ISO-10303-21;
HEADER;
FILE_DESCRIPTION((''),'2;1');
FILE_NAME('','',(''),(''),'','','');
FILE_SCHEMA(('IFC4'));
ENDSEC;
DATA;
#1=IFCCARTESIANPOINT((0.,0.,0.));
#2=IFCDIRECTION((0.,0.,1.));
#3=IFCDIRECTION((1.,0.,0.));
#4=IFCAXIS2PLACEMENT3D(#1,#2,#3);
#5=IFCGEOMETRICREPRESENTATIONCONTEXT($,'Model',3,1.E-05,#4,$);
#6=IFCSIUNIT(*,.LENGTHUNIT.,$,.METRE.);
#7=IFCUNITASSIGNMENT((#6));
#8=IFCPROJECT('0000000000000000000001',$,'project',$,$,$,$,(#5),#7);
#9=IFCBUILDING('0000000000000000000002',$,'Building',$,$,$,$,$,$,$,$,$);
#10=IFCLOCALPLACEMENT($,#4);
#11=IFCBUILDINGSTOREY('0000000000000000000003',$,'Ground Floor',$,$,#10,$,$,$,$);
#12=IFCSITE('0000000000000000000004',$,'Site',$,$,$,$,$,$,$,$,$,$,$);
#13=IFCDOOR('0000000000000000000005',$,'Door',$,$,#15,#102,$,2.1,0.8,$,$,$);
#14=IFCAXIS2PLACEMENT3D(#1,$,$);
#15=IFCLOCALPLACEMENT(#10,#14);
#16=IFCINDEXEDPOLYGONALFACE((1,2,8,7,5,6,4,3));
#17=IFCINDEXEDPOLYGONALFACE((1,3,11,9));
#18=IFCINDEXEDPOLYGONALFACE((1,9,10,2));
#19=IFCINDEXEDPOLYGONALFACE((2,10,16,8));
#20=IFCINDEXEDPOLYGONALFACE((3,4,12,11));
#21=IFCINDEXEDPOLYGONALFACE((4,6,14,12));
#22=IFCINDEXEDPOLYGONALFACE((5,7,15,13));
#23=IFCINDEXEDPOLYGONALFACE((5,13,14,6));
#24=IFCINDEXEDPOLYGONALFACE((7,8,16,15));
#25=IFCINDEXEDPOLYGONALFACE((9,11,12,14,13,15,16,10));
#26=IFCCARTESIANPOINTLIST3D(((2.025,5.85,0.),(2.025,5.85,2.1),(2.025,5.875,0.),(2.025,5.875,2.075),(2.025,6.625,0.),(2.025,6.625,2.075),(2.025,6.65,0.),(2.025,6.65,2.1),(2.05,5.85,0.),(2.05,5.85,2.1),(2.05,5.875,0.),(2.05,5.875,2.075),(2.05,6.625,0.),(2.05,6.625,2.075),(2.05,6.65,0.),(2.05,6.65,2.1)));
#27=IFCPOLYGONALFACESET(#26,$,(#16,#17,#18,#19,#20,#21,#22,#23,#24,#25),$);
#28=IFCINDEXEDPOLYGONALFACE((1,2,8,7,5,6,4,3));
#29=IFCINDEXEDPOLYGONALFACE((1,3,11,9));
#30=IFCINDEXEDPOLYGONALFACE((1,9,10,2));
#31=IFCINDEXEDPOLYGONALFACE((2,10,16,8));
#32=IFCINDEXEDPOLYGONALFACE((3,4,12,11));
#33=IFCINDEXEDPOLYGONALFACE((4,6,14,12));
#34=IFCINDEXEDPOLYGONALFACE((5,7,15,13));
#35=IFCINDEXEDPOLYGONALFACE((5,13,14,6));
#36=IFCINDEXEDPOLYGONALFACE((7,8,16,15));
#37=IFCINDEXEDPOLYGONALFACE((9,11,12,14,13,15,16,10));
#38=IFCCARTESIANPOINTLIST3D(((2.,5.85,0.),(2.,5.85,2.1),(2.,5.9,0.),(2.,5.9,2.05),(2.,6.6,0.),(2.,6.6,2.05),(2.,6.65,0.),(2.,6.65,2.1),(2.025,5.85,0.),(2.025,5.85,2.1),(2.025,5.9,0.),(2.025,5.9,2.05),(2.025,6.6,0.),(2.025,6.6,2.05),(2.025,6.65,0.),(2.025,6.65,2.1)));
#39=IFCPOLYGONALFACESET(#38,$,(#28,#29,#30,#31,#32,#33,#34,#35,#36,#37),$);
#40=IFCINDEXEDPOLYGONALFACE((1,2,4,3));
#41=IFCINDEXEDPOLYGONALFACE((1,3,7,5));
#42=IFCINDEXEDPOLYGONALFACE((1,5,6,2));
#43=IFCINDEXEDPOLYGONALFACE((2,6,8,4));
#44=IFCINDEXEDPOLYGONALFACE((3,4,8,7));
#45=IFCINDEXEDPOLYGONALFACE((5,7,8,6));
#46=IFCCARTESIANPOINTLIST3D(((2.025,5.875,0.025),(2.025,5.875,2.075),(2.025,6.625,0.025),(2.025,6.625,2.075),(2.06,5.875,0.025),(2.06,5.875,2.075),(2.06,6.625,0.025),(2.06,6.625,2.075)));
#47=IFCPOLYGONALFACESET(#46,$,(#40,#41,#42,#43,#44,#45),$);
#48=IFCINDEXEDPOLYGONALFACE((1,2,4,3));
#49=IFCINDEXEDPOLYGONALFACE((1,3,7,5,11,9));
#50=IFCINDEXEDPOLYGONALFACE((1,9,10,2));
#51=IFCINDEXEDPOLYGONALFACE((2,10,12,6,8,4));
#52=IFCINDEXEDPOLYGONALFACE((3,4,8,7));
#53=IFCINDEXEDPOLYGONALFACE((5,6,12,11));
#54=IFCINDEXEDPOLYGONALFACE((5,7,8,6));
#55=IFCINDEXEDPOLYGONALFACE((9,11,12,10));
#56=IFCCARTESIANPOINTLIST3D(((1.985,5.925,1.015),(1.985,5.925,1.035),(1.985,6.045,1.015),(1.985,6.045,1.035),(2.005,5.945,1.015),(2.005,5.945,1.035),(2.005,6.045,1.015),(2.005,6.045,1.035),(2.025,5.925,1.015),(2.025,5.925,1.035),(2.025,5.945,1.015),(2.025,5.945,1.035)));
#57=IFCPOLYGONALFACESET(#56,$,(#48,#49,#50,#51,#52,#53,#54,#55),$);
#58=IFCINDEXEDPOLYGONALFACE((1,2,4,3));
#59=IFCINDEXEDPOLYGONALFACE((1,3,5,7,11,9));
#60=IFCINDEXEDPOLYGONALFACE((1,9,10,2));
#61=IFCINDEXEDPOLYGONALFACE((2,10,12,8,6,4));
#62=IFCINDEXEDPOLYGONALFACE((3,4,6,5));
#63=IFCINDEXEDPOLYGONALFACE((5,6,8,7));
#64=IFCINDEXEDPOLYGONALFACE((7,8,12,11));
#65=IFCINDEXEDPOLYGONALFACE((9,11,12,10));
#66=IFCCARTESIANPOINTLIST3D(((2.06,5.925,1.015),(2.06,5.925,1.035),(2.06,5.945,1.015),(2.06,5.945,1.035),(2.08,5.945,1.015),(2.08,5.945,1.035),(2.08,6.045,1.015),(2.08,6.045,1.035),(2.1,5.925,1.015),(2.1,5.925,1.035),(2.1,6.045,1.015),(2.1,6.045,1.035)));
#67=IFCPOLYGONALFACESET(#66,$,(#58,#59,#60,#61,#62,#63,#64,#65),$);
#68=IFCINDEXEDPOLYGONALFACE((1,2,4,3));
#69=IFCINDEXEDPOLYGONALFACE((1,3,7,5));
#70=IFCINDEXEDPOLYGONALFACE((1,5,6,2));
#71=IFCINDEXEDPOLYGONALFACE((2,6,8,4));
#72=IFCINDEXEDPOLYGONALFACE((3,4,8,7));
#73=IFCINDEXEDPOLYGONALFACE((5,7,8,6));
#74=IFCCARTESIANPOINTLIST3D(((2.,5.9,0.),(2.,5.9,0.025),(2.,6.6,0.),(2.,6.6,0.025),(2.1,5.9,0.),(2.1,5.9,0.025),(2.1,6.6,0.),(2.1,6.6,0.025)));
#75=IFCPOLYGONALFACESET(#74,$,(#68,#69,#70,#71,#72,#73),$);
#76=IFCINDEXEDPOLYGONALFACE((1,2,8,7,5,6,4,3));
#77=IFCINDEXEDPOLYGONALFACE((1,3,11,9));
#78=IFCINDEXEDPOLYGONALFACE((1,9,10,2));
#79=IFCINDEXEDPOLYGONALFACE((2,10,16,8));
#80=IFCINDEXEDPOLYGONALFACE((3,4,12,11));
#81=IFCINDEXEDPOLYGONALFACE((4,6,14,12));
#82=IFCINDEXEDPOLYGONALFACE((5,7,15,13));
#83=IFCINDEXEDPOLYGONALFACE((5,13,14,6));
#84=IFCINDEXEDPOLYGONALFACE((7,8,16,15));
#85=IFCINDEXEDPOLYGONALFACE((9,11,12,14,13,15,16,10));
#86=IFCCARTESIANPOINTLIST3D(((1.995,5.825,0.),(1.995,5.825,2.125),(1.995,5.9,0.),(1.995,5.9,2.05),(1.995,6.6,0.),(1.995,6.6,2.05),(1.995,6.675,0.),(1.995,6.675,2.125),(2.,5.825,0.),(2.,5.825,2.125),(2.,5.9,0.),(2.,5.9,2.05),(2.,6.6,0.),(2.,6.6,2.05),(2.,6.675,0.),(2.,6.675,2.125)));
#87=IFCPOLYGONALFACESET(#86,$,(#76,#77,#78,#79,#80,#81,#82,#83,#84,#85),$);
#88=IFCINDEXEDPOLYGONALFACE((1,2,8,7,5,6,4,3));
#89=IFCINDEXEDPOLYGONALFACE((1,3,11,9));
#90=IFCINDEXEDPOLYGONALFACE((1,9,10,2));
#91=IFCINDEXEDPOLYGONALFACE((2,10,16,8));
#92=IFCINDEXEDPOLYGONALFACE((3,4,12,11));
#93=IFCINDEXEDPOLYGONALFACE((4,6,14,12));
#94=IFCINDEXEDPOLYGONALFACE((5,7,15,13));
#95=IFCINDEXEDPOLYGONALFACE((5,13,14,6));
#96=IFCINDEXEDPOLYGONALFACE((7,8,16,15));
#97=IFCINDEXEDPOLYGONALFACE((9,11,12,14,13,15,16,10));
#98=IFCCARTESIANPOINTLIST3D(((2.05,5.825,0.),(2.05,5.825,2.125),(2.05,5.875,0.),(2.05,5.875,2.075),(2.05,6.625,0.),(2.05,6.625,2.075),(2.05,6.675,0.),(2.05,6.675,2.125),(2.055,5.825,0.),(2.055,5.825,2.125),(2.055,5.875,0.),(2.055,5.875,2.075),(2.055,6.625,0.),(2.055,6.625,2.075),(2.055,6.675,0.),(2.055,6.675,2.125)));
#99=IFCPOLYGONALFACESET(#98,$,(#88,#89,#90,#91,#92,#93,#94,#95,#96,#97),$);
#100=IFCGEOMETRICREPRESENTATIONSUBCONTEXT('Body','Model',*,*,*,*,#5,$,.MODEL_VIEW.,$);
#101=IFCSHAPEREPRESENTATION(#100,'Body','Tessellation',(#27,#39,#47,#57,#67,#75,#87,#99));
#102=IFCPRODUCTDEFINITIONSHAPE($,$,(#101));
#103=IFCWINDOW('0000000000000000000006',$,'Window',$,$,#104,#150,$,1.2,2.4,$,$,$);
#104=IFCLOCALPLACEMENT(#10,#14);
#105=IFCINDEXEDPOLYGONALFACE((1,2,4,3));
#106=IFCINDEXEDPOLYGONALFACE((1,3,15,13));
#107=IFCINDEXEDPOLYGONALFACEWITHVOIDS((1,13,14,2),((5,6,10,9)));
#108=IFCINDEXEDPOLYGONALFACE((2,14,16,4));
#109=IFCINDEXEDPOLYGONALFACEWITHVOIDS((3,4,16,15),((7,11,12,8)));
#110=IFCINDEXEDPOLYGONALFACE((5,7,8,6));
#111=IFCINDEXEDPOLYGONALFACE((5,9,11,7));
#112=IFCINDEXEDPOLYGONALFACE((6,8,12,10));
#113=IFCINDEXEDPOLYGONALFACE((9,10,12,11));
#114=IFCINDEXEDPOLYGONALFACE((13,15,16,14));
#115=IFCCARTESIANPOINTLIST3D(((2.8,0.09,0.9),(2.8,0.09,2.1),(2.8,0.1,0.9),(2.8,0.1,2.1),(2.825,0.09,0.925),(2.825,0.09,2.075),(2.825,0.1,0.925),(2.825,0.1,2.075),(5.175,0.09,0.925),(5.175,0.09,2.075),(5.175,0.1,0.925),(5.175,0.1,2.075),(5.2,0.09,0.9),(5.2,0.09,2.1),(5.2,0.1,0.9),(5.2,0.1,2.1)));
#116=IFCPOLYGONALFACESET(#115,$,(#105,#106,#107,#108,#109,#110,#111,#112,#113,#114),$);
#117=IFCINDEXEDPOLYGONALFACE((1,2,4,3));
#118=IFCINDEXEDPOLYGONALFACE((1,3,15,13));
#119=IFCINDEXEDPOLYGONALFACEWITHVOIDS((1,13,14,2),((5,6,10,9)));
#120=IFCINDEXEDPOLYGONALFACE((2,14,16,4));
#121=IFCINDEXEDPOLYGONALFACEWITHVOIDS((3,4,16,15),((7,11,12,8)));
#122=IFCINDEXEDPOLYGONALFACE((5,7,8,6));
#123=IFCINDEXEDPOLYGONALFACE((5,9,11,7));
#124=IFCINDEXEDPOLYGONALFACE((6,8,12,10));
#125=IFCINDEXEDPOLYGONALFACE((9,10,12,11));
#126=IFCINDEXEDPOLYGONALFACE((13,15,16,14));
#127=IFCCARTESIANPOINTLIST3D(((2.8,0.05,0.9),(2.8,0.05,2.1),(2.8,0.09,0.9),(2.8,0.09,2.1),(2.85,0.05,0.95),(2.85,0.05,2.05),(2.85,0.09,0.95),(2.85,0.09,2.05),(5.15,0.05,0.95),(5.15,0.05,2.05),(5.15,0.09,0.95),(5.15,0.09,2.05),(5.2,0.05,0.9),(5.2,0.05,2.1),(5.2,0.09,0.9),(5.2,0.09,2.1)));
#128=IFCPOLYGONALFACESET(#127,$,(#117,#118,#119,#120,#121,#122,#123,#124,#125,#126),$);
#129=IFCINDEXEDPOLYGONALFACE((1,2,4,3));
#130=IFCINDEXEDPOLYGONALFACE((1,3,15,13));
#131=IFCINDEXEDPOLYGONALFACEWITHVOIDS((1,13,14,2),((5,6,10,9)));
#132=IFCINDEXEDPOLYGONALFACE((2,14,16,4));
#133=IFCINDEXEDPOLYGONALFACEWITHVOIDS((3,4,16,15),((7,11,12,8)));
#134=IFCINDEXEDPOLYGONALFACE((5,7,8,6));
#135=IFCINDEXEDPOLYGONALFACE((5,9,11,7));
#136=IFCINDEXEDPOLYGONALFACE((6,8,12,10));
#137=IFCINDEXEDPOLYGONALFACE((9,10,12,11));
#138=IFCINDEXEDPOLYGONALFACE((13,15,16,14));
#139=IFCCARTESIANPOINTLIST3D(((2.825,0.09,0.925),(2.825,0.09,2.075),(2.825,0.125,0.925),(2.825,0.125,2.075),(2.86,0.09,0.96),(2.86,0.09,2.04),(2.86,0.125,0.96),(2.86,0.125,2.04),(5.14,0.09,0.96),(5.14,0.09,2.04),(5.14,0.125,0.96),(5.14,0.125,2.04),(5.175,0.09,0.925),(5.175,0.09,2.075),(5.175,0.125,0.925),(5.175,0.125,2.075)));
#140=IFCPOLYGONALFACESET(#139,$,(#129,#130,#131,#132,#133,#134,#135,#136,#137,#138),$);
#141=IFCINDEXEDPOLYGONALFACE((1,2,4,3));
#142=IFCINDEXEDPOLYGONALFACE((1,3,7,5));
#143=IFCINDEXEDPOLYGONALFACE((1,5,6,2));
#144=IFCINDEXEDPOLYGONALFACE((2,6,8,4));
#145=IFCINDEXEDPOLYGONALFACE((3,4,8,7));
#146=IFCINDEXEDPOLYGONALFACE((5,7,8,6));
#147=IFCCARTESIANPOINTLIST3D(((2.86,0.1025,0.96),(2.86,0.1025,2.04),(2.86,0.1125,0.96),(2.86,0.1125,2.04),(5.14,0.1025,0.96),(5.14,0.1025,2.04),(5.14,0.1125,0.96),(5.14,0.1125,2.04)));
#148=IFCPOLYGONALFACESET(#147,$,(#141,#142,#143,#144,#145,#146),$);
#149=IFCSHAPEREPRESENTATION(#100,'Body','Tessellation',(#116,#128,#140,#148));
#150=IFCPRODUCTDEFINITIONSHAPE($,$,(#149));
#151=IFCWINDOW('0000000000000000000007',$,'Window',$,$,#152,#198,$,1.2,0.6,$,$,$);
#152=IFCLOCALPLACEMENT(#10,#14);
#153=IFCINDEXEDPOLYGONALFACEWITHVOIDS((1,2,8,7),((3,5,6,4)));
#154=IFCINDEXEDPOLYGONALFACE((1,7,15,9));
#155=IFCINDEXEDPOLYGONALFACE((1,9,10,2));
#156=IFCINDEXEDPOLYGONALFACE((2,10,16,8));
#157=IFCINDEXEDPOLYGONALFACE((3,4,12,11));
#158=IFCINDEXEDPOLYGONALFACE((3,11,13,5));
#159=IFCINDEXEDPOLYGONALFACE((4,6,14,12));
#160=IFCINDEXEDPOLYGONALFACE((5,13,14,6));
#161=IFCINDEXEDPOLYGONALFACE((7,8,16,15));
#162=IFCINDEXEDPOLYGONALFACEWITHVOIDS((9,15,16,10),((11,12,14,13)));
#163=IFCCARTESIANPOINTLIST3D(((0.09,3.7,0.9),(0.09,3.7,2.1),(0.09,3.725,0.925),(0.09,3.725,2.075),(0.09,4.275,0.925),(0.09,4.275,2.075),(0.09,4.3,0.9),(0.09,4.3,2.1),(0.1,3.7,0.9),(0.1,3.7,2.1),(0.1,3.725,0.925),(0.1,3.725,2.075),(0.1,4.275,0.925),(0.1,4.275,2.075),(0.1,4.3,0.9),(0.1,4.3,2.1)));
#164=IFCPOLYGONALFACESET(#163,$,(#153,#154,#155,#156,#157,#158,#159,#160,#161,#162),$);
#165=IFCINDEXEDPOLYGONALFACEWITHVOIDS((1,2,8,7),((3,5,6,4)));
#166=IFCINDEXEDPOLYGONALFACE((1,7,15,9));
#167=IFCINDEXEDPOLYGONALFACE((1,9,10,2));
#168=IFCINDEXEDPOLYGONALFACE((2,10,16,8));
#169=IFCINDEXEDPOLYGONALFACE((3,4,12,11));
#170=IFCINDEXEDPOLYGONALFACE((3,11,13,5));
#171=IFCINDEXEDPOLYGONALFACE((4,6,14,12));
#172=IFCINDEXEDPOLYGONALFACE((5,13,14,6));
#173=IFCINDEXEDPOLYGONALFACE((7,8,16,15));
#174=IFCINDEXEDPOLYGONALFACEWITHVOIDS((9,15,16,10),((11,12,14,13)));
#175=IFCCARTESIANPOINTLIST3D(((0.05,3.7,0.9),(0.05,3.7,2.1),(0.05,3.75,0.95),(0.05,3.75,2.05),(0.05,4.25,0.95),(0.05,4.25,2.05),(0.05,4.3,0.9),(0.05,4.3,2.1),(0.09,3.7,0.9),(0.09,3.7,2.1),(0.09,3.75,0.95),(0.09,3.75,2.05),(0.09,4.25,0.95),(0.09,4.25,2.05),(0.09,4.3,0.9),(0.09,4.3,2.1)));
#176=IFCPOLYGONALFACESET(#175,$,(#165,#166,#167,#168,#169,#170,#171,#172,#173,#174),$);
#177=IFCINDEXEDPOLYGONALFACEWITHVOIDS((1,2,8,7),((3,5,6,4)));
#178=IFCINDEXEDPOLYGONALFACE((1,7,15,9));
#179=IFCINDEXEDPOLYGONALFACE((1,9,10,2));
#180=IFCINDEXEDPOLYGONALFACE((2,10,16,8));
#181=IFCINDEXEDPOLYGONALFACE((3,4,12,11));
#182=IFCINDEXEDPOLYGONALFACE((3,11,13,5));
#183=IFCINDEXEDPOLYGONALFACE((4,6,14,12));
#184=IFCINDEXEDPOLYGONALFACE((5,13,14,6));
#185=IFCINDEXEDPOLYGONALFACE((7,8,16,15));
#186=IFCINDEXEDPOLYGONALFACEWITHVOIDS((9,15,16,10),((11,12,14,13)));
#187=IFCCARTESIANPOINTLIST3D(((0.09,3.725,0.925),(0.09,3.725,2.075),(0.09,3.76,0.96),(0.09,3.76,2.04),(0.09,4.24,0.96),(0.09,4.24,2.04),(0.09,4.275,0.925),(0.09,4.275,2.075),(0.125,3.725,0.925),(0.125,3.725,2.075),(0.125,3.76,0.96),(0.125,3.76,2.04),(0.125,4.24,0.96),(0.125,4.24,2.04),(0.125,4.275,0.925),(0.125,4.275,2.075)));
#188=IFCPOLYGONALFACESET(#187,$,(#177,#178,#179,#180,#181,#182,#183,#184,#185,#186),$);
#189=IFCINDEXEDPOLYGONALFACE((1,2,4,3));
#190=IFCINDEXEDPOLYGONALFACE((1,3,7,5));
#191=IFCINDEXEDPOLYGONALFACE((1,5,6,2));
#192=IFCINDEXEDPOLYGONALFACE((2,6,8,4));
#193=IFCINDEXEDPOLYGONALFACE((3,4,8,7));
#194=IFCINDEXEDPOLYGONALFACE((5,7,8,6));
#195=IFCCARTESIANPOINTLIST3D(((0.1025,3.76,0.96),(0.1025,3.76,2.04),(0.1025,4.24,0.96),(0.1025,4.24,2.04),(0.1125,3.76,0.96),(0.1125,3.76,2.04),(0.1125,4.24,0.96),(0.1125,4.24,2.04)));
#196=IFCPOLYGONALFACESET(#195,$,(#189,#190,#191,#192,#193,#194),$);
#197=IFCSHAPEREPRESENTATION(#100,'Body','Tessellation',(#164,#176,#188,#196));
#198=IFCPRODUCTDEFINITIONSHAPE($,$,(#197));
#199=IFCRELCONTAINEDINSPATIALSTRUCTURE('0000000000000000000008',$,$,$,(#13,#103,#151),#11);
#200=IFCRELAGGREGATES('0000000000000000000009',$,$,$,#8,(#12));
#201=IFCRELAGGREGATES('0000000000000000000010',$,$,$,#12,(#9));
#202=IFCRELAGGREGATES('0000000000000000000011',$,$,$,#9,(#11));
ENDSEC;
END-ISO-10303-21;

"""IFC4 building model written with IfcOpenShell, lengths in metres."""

from ifc_helpers import new_model, si_unit, frame, origin_with_axes, place, context, subcontext, project, spatial, line, indexed_curve, outline, extrude, element, save


model = new_model("IFC4")

# Units and contexts
model_context = context("Model", 3, precision=1e-05, world=origin_with_axes())
body_context = subcontext(model_context, "Body", "Model", "MODEL_VIEW")
ifc_project = project(units=[si_unit("LENGTHUNIT", "METRE")], contexts=[model_context])

# Site, building, storey
site = spatial("IfcSite", under=ifc_project, Name="Site")
building = spatial("IfcBuilding", under=site, Name="Building")
storey_placement = place(None, origin_with_axes())
storey = spatial("IfcBuildingStorey", under=building, at=storey_placement, Name="Ground Floor")

# Door
door_1_placement = place(storey_placement, frame((2.0, 6.65, 0.0), z_axis=(0.0, 0.0, 1.0), x_axis=(0.0, -1.0, 0.0)))
element("IfcDoor", 1, at=door_1_placement, inside=storey, Name="Door", OverallHeight=2.1, OverallWidth=0.8, context=body_context, shape_type="SweptSolid", body=[
    extrude(outline(indexed_curve([(0.0, 0.0), (0.0, 2.1), (0.8, 2.1), (0.8, 0.0), (0.775, 0.0), (0.775, 2.075), (0.025, 2.075), (0.025, 0.0)], segments=[line(1, 2, 3, 4, 5, 6, 7, 8, 1)])), frame((0.0, 0.025, 0.0), z_axis=(0.0, -1.0, 0.0), x_axis=(1.0, 0.0, 0.0)), (0.0, 0.0, -1.0), 0.025),
    extrude(outline(indexed_curve([(0.0, 0.0), (0.0, 2.1), (0.8, 2.1), (0.8, 0.0), (0.75, 0.0), (0.75, 2.05), (0.05, 2.05), (0.05, 0.0)], segments=[line(1, 2, 3, 4, 5, 6, 7, 8, 1)])), frame((0.0, 0.0, 0.0), z_axis=(0.0, -1.0, 0.0), x_axis=(1.0, 0.0, 0.0)), (0.0, 0.0, -1.0), 0.025),
    extrude(outline(indexed_curve([(0.0, 0.0), (0.75, 0.0), (0.75, 0.035), (0.0, 0.035)], segments=[line(1, 2, 3, 4, 1)])), frame((0.025, 0.025, 0.025), z_axis=(0.0, 0.0, 1.0), x_axis=(1.0, 0.0, 0.0)), (0.0, 0.0, 1.0), 2.05),
    extrude(outline(indexed_curve([(0.0, 0.0), (0.0, -0.04), (-0.12, -0.04), (-0.12, -0.02), (-0.02, -0.02), (-0.02, 0.0)], segments=[line(1, 2, 3, 4, 5, 6, 1)])), frame((0.725, 0.025, 1.015), z_axis=(0.0, 0.0, 1.0), x_axis=(1.0, 0.0, 0.0)), (0.0, 0.0, 1.0), 0.02),
    extrude(outline(indexed_curve([(0.0, 0.0), (0.0, 0.04), (-0.12, 0.04), (-0.12, 0.02), (-0.02, 0.02), (-0.02, 0.0)], segments=[line(1, 2, 3, 4, 5, 6, 1)])), frame((0.725, 0.06, 1.015), z_axis=(0.0, 0.0, 1.0), x_axis=(1.0, 0.0, 0.0)), (0.0, 0.0, 1.0), 0.02),
    extrude(outline(indexed_curve([(0.0, 0.0), (0.7, 0.0), (0.7, 0.1), (0.0, 0.1)], segments=[line(1, 2, 3, 4, 1)])), frame((0.05, 0.0, 0.0), z_axis=(0.0, 0.0, 1.0), x_axis=(1.0, 0.0, 0.0)), (0.0, 0.0, 1.0), 0.025),
    extrude(outline(indexed_curve([(0.0, 0.0), (0.0, 2.125), (0.85, 2.125), (0.85, 0.0), (0.775, 0.0), (0.775, 2.05), (0.075, 2.05), (0.075, 0.0)], segments=[line(1, 2, 3, 4, 5, 6, 7, 8, 1)])), frame((-0.025, -0.005, 0.0), z_axis=(0.0, -1.0, 0.0), x_axis=(1.0, 0.0, 0.0)), (0.0, 0.0, -1.0), 0.005),
    extrude(outline(indexed_curve([(0.0, 0.0), (0.0, 2.125), (0.85, 2.125), (0.85, 0.0), (0.8, 0.0), (0.8, 2.075), (0.05, 2.075), (0.05, 0.0)], segments=[line(1, 2, 3, 4, 5, 6, 7, 8, 1)])), frame((-0.025, 0.05, 0.0), z_axis=(0.0, -1.0, 0.0), x_axis=(1.0, 0.0, 0.0)), (0.0, 0.0, -1.0), 0.005),
])

# Windows
window_1_placement = place(storey_placement, frame((2.8, 0.0, 0.9), z_axis=(0.0, 0.0, 1.0), x_axis=(1.0, 0.0, 0.0)))
element("IfcWindow", 2, at=window_1_placement, inside=storey, Name="Window", OverallHeight=1.2, OverallWidth=2.4, context=body_context, shape_type="SweptSolid", body=[
    extrude(outline(indexed_curve([(0.0, 0.0), (2.4, 0.0), (2.4, 1.2), (0.0, 1.2)], segments=[line(1, 2, 3, 4, 1)]), holes=[indexed_curve([(0.025, 0.025), (2.375, 0.025), (2.375, 1.175), (0.025, 1.175)], segments=[line(1, 2, 3, 4, 1)])]), frame((0.0, 0.09, 0.0), z_axis=(0.0, -1.0, 0.0), x_axis=(1.0, 0.0, 0.0)), (0.0, 0.0, -1.0), 0.01),
    extrude(outline(indexed_curve([(0.0, 0.0), (2.4, 0.0), (2.4, 1.2), (0.0, 1.2)], segments=[line(1, 2, 3, 4, 1)]), holes=[indexed_curve([(0.05, 0.05), (2.35, 0.05), (2.35, 1.15), (0.05, 1.15)], segments=[line(1, 2, 3, 4, 1)])]), frame((0.0, 0.05, 0.0), z_axis=(0.0, -1.0, 0.0), x_axis=(1.0, 0.0, 0.0)), (0.0, 0.0, -1.0), 0.04),
    extrude(outline(indexed_curve([(0.0, 0.0), (2.35, 0.0), (2.35, 1.15), (0.0, 1.15)], segments=[line(1, 2, 3, 4, 1)]), holes=[indexed_curve([(0.035, 0.035), (2.315, 0.035), (2.315, 1.115), (0.035, 1.115)], segments=[line(1, 2, 3, 4, 1)])]), frame((0.025, 0.09, 0.025), z_axis=(0.0, -1.0, 0.0), x_axis=(1.0, 0.0, 0.0)), (0.0, 0.0, -1.0), 0.035),
    extrude(outline(indexed_curve([(0.035, 0.035), (2.315, 0.035), (2.315, 1.115), (0.035, 1.115)], segments=[line(1, 2, 3, 4, 1)])), frame((0.025, 0.1025, 0.025), z_axis=(0.0, -1.0, 0.0), x_axis=(1.0, 0.0, 0.0)), (0.0, 0.0, -1.0), 0.01),
])
window_2_placement = place(storey_placement, frame((0.0, 4.3, 0.9), z_axis=(0.0, 0.0, 1.0), x_axis=(0.0, -1.0, 0.0)))
element("IfcWindow", 3, at=window_2_placement, inside=storey, Name="Window", OverallHeight=1.2, OverallWidth=0.6, context=body_context, shape_type="SweptSolid", body=[
    extrude(outline(indexed_curve([(0.0, 0.0), (0.6, 0.0), (0.6, 1.2), (0.0, 1.2)], segments=[line(1, 2, 3, 4, 1)]), holes=[indexed_curve([(0.025, 0.025), (0.575, 0.025), (0.575, 1.175), (0.025, 1.175)], segments=[line(1, 2, 3, 4, 1)])]), frame((0.0, 0.09, 0.0), z_axis=(0.0, -1.0, 0.0), x_axis=(1.0, 0.0, 0.0)), (0.0, 0.0, -1.0), 0.01),
    extrude(outline(indexed_curve([(0.0, 0.0), (0.6, 0.0), (0.6, 1.2), (0.0, 1.2)], segments=[line(1, 2, 3, 4, 1)]), holes=[indexed_curve([(0.05, 0.05), (0.55, 0.05), (0.55, 1.15), (0.05, 1.15)], segments=[line(1, 2, 3, 4, 1)])]), frame((0.0, 0.05, 0.0), z_axis=(0.0, -1.0, 0.0), x_axis=(1.0, 0.0, 0.0)), (0.0, 0.0, -1.0), 0.04),
    extrude(outline(indexed_curve([(0.0, 0.0), (0.55, 0.0), (0.55, 1.15), (0.0, 1.15)], segments=[line(1, 2, 3, 4, 1)]), holes=[indexed_curve([(0.035, 0.035), (0.515, 0.035), (0.515, 1.115), (0.035, 1.115)], segments=[line(1, 2, 3, 4, 1)])]), frame((0.025, 0.09, 0.025), z_axis=(0.0, -1.0, 0.0), x_axis=(1.0, 0.0, 0.0)), (0.0, 0.0, -1.0), 0.035),
    extrude(outline(indexed_curve([(0.035, 0.035), (0.515, 0.035), (0.515, 1.115), (0.035, 1.115)], segments=[line(1, 2, 3, 4, 1)])), frame((0.025, 0.1025, 0.025), z_axis=(0.0, -1.0, 0.0), x_axis=(1.0, 0.0, 0.0)), (0.0, 0.0, -1.0), 0.01),
])

save(model, "model.ifc")
